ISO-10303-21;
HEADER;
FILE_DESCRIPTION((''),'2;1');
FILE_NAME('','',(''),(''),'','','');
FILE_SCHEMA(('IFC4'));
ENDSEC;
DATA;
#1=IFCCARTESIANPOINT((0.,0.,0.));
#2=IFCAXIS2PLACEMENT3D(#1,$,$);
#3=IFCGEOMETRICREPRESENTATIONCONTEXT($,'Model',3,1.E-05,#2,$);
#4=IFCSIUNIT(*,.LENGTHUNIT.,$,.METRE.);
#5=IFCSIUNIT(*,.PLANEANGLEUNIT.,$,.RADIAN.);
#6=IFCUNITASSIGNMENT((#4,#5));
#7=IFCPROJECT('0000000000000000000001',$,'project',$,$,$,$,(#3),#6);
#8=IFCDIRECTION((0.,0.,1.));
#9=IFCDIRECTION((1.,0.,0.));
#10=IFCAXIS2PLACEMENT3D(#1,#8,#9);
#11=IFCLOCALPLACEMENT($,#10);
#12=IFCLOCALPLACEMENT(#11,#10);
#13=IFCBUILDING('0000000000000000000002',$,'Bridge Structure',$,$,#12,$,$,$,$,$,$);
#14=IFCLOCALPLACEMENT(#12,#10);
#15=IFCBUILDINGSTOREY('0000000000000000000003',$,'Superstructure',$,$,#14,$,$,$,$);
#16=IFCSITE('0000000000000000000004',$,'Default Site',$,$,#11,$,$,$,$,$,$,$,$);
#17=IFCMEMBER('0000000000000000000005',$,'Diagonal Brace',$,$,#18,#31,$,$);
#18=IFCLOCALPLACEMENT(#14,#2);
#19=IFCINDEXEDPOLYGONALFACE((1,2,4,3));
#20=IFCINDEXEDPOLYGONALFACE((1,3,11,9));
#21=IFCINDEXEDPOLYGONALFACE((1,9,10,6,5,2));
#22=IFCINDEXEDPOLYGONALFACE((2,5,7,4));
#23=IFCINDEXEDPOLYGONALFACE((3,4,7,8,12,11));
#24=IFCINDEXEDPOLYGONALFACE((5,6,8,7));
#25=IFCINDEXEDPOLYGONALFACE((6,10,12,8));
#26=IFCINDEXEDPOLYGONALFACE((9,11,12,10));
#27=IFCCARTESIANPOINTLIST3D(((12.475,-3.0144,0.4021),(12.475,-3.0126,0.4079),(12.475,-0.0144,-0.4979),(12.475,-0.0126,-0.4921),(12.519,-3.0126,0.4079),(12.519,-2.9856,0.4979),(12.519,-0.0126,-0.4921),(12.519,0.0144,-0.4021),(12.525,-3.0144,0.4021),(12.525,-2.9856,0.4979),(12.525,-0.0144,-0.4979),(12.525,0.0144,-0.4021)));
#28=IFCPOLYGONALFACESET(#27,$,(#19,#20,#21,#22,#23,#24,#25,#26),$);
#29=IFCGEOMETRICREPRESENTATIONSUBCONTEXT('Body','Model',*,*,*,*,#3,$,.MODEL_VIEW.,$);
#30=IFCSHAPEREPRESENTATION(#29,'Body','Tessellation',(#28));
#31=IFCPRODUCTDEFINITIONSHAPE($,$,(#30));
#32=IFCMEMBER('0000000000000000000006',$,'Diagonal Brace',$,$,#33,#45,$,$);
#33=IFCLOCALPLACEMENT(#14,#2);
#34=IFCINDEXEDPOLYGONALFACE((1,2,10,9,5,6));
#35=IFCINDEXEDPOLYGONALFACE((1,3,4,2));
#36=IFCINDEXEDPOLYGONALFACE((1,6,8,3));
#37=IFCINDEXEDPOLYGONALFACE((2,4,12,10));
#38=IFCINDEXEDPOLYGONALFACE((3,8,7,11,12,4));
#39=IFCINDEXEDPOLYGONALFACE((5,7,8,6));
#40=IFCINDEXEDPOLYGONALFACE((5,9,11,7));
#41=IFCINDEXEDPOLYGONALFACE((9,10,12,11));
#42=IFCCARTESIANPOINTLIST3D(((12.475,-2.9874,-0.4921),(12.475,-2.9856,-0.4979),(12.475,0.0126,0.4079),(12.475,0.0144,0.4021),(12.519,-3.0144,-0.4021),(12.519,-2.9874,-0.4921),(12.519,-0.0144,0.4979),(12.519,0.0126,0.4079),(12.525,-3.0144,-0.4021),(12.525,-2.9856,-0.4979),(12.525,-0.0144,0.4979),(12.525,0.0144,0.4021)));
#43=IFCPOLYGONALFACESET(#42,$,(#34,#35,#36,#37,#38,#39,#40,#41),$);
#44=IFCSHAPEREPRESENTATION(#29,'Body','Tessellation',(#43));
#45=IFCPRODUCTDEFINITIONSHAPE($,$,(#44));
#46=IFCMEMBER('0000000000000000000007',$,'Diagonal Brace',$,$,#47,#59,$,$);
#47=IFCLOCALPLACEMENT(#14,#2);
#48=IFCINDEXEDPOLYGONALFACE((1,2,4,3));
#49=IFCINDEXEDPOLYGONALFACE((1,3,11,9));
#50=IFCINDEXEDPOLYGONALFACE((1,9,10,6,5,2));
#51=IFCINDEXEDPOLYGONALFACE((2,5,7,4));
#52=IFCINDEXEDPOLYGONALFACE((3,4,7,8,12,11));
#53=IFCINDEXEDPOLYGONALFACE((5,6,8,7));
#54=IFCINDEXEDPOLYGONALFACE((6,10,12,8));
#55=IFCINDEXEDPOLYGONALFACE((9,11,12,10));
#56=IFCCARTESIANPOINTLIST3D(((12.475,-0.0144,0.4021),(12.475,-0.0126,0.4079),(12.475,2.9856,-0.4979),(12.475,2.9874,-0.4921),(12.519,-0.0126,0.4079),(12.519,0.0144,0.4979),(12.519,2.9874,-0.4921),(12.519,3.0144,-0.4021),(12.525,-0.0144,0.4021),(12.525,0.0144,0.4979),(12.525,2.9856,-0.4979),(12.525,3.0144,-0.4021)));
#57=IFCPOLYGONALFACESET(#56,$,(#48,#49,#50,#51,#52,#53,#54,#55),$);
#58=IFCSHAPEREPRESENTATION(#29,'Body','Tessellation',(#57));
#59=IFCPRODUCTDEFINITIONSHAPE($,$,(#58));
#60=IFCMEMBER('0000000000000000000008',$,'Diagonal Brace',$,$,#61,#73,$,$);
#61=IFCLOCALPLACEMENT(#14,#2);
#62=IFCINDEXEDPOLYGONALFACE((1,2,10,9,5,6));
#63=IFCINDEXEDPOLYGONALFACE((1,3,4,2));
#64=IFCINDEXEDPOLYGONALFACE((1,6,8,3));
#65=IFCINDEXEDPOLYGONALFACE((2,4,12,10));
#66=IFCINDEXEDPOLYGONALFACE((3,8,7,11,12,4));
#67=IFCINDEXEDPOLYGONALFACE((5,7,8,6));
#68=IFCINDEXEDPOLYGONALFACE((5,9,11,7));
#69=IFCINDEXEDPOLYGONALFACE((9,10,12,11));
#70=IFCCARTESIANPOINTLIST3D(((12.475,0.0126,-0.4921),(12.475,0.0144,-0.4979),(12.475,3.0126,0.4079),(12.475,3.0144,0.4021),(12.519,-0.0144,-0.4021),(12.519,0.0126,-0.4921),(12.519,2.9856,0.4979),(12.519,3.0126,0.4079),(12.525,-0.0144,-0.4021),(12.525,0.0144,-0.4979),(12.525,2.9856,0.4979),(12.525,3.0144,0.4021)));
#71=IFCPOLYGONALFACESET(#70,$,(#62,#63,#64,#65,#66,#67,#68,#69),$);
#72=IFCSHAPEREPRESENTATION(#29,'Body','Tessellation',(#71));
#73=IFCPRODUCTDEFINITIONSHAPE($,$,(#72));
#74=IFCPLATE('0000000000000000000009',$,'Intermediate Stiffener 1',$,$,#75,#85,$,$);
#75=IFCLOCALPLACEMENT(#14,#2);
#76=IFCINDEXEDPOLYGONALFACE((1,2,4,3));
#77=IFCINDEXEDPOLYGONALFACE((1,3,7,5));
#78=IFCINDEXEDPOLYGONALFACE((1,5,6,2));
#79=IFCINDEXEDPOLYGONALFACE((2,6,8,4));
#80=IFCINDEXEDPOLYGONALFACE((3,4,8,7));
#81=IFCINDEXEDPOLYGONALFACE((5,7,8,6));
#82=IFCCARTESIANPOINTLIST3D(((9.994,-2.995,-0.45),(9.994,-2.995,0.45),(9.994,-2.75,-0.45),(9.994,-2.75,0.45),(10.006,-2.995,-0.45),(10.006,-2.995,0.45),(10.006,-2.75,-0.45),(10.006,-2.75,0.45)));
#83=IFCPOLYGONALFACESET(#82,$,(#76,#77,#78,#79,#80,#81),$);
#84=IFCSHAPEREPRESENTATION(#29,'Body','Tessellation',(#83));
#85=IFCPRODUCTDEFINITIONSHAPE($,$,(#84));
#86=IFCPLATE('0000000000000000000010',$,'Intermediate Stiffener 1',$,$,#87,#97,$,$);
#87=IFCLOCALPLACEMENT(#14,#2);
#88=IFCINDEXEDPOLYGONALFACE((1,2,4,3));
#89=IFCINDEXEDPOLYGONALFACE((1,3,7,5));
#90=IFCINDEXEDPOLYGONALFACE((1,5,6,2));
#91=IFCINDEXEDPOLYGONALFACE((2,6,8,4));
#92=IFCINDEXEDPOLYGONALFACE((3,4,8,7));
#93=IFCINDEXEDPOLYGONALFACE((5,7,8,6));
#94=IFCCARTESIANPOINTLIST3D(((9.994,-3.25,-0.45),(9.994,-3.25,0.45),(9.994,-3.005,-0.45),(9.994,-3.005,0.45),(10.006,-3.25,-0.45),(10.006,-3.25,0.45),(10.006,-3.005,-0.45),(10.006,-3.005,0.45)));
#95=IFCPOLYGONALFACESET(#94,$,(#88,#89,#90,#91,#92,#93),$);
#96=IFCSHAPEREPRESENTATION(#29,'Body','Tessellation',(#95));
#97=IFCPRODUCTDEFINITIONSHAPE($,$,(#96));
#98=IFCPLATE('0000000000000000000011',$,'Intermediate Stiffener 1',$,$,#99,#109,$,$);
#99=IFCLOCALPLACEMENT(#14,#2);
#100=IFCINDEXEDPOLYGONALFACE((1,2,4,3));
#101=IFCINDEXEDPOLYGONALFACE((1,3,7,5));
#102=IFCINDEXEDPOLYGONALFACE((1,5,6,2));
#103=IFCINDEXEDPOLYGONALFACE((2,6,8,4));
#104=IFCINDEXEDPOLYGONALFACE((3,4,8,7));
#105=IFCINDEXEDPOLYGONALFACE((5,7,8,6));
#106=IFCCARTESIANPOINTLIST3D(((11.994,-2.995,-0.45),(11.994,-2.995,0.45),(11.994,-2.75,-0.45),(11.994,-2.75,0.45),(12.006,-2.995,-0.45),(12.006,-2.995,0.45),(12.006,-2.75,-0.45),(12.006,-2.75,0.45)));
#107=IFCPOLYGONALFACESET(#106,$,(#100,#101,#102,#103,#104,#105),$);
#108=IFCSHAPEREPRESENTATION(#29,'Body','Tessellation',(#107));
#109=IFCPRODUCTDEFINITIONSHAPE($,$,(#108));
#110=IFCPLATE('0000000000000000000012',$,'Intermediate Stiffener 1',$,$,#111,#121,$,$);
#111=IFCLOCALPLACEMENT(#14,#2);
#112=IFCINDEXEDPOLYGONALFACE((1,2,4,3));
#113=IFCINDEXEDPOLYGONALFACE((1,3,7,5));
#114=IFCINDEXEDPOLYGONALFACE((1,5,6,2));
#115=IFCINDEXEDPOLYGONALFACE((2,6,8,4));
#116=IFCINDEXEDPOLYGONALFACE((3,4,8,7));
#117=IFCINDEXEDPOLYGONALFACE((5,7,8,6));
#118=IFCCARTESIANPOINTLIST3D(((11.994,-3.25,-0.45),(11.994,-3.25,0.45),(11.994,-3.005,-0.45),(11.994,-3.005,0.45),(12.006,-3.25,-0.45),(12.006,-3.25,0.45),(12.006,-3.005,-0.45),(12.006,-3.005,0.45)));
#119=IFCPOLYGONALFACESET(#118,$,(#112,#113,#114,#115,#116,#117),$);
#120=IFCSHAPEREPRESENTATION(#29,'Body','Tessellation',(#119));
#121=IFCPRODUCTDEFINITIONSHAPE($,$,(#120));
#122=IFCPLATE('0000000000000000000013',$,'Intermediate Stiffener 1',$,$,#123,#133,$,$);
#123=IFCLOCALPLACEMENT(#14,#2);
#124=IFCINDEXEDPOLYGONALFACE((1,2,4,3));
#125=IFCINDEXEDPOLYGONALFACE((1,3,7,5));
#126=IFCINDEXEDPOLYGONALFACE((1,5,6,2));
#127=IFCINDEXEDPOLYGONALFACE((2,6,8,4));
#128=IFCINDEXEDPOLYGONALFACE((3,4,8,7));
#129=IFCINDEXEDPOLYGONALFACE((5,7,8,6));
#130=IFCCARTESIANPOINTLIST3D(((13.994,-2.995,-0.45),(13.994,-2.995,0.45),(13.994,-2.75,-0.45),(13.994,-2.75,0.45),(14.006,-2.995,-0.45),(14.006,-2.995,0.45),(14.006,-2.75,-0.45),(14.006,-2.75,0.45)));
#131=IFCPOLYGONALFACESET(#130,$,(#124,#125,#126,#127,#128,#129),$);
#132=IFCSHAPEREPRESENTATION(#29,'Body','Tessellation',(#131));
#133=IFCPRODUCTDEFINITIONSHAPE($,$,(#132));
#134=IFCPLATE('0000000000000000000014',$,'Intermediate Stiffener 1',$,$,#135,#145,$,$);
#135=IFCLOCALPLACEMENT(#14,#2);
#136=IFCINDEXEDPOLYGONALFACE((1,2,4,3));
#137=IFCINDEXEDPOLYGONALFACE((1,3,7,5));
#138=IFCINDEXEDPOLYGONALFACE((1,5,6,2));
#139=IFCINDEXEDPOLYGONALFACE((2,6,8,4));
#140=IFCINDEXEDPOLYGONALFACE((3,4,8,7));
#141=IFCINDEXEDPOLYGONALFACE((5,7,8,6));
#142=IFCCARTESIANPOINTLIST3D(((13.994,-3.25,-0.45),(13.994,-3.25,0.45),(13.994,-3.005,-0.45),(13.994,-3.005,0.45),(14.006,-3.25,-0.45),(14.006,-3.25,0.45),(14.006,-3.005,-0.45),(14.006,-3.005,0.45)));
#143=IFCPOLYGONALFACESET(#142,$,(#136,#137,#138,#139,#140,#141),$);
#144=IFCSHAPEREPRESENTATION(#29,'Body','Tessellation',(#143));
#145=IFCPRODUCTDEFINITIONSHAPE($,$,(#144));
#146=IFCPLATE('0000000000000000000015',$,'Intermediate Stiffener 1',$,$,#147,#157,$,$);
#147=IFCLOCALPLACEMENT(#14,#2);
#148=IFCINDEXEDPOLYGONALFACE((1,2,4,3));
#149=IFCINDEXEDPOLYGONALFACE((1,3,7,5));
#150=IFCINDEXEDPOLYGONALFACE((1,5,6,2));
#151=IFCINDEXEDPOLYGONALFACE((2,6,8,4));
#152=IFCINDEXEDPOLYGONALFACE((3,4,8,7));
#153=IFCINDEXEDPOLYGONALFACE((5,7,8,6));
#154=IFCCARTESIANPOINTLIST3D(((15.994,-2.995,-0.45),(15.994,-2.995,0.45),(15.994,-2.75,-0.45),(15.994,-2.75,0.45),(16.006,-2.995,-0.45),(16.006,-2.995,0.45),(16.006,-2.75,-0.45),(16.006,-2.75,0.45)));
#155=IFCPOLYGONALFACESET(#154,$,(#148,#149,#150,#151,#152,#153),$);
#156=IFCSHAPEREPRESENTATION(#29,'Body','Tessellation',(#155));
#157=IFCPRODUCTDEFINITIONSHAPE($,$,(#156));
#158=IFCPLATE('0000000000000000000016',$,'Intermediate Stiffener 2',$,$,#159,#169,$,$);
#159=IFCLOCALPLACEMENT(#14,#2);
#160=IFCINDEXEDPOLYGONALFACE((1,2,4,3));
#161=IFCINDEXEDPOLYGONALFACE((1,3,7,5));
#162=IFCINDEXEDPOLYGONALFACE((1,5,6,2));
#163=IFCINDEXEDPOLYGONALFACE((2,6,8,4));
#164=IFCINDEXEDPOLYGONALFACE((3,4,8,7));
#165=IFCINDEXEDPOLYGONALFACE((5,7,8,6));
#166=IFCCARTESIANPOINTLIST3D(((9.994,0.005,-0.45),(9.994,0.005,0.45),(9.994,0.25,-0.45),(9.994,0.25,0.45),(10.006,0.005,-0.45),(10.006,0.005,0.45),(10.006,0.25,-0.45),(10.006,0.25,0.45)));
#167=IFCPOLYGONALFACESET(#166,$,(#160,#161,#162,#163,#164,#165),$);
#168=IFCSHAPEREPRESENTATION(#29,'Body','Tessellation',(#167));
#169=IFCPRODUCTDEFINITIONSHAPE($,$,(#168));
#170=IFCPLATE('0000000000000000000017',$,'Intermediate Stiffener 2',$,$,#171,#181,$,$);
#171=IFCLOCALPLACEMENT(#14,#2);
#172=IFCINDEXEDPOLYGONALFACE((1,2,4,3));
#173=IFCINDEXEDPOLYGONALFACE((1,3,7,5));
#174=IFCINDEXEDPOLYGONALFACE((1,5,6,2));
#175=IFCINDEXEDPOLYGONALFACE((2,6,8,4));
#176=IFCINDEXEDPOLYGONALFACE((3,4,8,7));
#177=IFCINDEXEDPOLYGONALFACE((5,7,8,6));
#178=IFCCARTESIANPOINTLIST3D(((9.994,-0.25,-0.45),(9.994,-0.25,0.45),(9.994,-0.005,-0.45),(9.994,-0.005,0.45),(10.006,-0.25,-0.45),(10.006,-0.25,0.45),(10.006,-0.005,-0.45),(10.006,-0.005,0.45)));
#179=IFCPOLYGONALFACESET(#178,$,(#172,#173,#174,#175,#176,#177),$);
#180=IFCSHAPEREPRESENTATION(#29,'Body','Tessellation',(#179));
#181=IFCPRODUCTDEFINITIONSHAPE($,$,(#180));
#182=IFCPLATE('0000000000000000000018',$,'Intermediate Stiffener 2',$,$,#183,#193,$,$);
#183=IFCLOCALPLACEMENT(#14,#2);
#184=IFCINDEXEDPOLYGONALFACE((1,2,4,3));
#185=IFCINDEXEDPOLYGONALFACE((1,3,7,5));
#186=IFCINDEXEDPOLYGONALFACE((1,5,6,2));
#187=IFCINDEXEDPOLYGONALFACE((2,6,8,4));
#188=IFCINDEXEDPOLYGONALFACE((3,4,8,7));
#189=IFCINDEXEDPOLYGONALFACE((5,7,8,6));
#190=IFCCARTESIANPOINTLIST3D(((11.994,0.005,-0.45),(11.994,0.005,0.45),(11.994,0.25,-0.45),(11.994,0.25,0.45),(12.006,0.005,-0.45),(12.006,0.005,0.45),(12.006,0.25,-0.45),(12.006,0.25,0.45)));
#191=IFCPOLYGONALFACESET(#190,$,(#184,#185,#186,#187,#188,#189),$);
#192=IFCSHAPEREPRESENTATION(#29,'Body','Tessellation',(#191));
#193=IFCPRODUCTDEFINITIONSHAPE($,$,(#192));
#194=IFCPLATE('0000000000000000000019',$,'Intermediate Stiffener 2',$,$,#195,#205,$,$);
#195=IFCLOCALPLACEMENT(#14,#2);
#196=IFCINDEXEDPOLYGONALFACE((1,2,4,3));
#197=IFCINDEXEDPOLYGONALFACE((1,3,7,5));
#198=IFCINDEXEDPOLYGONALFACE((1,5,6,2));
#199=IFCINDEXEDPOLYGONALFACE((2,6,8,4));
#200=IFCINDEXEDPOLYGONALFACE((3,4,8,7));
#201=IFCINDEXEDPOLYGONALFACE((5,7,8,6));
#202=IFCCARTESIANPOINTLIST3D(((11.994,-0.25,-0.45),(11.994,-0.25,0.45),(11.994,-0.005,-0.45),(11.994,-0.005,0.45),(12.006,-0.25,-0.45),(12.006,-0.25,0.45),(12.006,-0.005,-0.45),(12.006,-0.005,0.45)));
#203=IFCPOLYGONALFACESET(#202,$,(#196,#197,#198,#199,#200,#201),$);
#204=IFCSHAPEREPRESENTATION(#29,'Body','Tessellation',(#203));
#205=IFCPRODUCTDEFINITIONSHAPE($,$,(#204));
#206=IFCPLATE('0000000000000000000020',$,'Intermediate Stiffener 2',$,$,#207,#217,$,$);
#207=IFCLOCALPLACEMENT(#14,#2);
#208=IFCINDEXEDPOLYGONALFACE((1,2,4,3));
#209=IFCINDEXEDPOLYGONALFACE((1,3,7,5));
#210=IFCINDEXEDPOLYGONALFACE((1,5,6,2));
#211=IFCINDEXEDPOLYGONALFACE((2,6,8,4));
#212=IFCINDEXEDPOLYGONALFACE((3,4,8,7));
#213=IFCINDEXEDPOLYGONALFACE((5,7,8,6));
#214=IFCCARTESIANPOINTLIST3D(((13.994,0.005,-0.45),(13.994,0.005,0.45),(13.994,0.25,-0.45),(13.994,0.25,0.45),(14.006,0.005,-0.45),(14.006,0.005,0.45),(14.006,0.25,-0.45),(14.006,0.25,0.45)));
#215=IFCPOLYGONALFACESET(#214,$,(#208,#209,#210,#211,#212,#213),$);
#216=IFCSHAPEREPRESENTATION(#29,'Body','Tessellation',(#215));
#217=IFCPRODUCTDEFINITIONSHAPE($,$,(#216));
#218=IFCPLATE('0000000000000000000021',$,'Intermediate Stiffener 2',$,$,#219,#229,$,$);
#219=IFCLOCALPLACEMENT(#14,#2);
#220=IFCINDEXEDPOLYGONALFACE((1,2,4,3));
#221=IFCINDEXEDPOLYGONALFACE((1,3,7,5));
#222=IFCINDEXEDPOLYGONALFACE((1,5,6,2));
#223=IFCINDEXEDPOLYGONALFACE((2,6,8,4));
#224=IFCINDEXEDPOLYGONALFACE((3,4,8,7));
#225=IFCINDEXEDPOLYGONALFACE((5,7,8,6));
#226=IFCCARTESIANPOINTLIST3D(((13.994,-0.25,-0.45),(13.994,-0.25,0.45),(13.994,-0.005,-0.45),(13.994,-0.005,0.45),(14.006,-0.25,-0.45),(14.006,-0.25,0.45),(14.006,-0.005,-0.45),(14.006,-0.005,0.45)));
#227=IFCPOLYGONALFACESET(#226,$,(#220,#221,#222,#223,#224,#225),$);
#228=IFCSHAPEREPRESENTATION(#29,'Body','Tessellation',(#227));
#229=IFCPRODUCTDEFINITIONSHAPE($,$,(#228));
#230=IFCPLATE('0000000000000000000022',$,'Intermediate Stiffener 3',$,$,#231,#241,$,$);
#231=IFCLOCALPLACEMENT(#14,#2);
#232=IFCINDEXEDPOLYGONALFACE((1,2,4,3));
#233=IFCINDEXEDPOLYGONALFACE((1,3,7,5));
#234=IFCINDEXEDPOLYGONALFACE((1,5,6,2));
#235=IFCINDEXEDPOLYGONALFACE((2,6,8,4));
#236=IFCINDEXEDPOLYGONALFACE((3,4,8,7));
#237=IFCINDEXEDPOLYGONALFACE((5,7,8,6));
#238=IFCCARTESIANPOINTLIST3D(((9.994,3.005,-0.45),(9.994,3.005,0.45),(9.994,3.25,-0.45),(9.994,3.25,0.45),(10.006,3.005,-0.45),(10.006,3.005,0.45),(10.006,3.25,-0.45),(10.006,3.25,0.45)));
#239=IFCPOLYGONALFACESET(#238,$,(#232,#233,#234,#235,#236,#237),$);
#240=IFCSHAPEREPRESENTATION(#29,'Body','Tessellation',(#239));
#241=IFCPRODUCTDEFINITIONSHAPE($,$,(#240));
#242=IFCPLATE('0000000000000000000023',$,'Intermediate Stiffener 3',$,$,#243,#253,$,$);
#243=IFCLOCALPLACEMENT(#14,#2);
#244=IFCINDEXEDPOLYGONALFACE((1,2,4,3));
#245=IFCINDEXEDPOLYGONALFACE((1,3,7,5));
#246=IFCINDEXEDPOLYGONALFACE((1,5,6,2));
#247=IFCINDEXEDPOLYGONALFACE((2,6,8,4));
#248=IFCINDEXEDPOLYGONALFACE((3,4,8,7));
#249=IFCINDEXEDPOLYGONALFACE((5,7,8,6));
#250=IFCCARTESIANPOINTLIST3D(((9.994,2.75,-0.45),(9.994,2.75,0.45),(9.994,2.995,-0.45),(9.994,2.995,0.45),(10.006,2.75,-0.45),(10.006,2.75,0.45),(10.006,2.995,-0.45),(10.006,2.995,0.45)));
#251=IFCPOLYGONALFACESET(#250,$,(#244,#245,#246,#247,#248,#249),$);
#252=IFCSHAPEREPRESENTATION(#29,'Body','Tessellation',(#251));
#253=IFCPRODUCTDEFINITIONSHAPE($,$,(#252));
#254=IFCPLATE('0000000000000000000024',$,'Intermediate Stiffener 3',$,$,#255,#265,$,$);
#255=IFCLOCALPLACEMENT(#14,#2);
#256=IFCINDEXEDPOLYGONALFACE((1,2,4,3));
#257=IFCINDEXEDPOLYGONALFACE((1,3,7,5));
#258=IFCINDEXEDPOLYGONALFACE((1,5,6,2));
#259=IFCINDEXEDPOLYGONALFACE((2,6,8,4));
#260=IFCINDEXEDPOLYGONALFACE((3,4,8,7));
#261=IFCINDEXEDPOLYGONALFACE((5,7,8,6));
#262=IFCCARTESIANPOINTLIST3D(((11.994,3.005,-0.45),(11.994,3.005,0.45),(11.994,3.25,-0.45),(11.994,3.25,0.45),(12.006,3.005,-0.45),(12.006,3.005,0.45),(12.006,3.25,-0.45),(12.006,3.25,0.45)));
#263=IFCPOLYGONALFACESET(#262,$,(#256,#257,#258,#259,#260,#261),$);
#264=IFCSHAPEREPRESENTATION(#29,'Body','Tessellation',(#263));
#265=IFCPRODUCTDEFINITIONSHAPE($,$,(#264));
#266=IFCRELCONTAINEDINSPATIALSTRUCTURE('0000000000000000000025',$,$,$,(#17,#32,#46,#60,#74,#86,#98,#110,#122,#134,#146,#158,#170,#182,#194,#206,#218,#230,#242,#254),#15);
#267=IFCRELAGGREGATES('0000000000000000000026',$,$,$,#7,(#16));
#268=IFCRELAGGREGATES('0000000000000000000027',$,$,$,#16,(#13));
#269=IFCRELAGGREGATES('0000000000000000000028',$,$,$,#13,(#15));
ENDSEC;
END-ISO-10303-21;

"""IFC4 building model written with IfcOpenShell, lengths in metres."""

from ifc_helpers import new_model, si_unit, frame, origin, origin_with_axes, origin_2d_with_axis, place, context, subcontext, project, spatial, rectangle, l_section, extrude, element, save


model = new_model("IFC4")

# Units and contexts
model_context = context("Model", 3, precision=1e-05, world=origin())
body_context = subcontext(model_context, "Body", "Model", "MODEL_VIEW")
ifc_project = project(units=[si_unit("LENGTHUNIT", "METRE"), si_unit("PLANEANGLEUNIT", "RADIAN")], contexts=[model_context])

# Site, building, storey
site_placement = place(None, origin_with_axes())
site = spatial("IfcSite", under=ifc_project, at=site_placement, Name="Default Site")
building_placement = place(site_placement, origin_with_axes())
building = spatial("IfcBuilding", under=site, at=building_placement, Name="Bridge Structure")
storey_placement = place(building_placement, origin_with_axes())
storey = spatial("IfcBuildingStorey", under=building, at=storey_placement, Name="Superstructure")

# Members
for number, where, z_axis, x_axis, name in (
    (1, (12.5, -3.0, 0.45), (0.0, 0.957826, -0.287348), (-1.0, 0.0, 0.0), "Diagonal Brace"),
    (2, (12.5, -3.0, -0.45), (0.0, 0.957826, 0.287348), (-1.0, 0.0, 0.0), "Diagonal Brace"),
    (3, (12.5, 0.0, 0.45), (0.0, 0.957826, -0.287348), (-1.0, 0.0, 0.0), "Diagonal Brace"),
    (4, (12.5, 0.0, -0.45), (0.0, 0.957826, 0.287348), (-1.0, 0.0, 0.0), "Diagonal Brace"),
):
    element("IfcMember", number, at=place(storey_placement, frame(where, z_axis=z_axis, x_axis=x_axis)), inside=storey, Name=name, context=body_context, shape_type="SweptSolid", body=[
        extrude(l_section(Depth=0.1, Width=0.05, Thickness=0.006, at=origin_2d_with_axis()), origin_with_axes(), (0.0, 0.0, 1.0), 3.1321),
    ])

# Plates
for number, where, z_axis, x_axis, name in (
    (5, (10.0, -2.8725, -0.45), (0.0, 0.0, 1.0), (1.0, 0.0, 0.0), "Intermediate Stiffener 1"),
    (6, (10.0, -3.1275, -0.45), (0.0, 0.0, 1.0), (1.0, 0.0, 0.0), "Intermediate Stiffener 1"),
    (7, (12.0, -2.8725, -0.45), (0.0, 0.0, 1.0), (1.0, 0.0, 0.0), "Intermediate Stiffener 1"),
    (8, (12.0, -3.1275, -0.45), (0.0, 0.0, 1.0), (1.0, 0.0, 0.0), "Intermediate Stiffener 1"),
    (9, (14.0, -2.8725, -0.45), (0.0, 0.0, 1.0), (1.0, 0.0, 0.0), "Intermediate Stiffener 1"),
    (10, (14.0, -3.1275, -0.45), (0.0, 0.0, 1.0), (1.0, 0.0, 0.0), "Intermediate Stiffener 1"),
    (11, (16.0, -2.8725, -0.45), (0.0, 0.0, 1.0), (1.0, 0.0, 0.0), "Intermediate Stiffener 1"),
    (12, (10.0, 0.1275, -0.45), (0.0, 0.0, 1.0), (1.0, 0.0, 0.0), "Intermediate Stiffener 2"),
    (13, (10.0, -0.1275, -0.45), (0.0, 0.0, 1.0), (1.0, 0.0, 0.0), "Intermediate Stiffener 2"),
    (14, (12.0, 0.1275, -0.45), (0.0, 0.0, 1.0), (1.0, 0.0, 0.0), "Intermediate Stiffener 2"),
    (15, (12.0, -0.1275, -0.45), (0.0, 0.0, 1.0), (1.0, 0.0, 0.0), "Intermediate Stiffener 2"),
    (16, (14.0, 0.1275, -0.45), (0.0, 0.0, 1.0), (1.0, 0.0, 0.0), "Intermediate Stiffener 2"),
    (17, (14.0, -0.1275, -0.45), (0.0, 0.0, 1.0), (1.0, 0.0, 0.0), "Intermediate Stiffener 2"),
    (18, (10.0, 3.1275, -0.45), (0.0, 0.0, 1.0), (1.0, 0.0, 0.0), "Intermediate Stiffener 3"),
    (19, (10.0, 2.8725, -0.45), (0.0, 0.0, 1.0), (1.0, 0.0, 0.0), "Intermediate Stiffener 3"),
    (20, (12.0, 3.1275, -0.45), (0.0, 0.0, 1.0), (1.0, 0.0, 0.0), "Intermediate Stiffener 3"),
):
    element("IfcPlate", number, at=place(storey_placement, frame(where, z_axis=z_axis, x_axis=x_axis)), inside=storey, Name=name, context=body_context, shape_type="SweptSolid", body=[
        extrude(rectangle(XDim=0.012, YDim=0.245, at=origin_2d_with_axis()), origin_with_axes(), (0.0, 0.0, 1.0), 0.9),
    ])

save(model, "model.ifc")
